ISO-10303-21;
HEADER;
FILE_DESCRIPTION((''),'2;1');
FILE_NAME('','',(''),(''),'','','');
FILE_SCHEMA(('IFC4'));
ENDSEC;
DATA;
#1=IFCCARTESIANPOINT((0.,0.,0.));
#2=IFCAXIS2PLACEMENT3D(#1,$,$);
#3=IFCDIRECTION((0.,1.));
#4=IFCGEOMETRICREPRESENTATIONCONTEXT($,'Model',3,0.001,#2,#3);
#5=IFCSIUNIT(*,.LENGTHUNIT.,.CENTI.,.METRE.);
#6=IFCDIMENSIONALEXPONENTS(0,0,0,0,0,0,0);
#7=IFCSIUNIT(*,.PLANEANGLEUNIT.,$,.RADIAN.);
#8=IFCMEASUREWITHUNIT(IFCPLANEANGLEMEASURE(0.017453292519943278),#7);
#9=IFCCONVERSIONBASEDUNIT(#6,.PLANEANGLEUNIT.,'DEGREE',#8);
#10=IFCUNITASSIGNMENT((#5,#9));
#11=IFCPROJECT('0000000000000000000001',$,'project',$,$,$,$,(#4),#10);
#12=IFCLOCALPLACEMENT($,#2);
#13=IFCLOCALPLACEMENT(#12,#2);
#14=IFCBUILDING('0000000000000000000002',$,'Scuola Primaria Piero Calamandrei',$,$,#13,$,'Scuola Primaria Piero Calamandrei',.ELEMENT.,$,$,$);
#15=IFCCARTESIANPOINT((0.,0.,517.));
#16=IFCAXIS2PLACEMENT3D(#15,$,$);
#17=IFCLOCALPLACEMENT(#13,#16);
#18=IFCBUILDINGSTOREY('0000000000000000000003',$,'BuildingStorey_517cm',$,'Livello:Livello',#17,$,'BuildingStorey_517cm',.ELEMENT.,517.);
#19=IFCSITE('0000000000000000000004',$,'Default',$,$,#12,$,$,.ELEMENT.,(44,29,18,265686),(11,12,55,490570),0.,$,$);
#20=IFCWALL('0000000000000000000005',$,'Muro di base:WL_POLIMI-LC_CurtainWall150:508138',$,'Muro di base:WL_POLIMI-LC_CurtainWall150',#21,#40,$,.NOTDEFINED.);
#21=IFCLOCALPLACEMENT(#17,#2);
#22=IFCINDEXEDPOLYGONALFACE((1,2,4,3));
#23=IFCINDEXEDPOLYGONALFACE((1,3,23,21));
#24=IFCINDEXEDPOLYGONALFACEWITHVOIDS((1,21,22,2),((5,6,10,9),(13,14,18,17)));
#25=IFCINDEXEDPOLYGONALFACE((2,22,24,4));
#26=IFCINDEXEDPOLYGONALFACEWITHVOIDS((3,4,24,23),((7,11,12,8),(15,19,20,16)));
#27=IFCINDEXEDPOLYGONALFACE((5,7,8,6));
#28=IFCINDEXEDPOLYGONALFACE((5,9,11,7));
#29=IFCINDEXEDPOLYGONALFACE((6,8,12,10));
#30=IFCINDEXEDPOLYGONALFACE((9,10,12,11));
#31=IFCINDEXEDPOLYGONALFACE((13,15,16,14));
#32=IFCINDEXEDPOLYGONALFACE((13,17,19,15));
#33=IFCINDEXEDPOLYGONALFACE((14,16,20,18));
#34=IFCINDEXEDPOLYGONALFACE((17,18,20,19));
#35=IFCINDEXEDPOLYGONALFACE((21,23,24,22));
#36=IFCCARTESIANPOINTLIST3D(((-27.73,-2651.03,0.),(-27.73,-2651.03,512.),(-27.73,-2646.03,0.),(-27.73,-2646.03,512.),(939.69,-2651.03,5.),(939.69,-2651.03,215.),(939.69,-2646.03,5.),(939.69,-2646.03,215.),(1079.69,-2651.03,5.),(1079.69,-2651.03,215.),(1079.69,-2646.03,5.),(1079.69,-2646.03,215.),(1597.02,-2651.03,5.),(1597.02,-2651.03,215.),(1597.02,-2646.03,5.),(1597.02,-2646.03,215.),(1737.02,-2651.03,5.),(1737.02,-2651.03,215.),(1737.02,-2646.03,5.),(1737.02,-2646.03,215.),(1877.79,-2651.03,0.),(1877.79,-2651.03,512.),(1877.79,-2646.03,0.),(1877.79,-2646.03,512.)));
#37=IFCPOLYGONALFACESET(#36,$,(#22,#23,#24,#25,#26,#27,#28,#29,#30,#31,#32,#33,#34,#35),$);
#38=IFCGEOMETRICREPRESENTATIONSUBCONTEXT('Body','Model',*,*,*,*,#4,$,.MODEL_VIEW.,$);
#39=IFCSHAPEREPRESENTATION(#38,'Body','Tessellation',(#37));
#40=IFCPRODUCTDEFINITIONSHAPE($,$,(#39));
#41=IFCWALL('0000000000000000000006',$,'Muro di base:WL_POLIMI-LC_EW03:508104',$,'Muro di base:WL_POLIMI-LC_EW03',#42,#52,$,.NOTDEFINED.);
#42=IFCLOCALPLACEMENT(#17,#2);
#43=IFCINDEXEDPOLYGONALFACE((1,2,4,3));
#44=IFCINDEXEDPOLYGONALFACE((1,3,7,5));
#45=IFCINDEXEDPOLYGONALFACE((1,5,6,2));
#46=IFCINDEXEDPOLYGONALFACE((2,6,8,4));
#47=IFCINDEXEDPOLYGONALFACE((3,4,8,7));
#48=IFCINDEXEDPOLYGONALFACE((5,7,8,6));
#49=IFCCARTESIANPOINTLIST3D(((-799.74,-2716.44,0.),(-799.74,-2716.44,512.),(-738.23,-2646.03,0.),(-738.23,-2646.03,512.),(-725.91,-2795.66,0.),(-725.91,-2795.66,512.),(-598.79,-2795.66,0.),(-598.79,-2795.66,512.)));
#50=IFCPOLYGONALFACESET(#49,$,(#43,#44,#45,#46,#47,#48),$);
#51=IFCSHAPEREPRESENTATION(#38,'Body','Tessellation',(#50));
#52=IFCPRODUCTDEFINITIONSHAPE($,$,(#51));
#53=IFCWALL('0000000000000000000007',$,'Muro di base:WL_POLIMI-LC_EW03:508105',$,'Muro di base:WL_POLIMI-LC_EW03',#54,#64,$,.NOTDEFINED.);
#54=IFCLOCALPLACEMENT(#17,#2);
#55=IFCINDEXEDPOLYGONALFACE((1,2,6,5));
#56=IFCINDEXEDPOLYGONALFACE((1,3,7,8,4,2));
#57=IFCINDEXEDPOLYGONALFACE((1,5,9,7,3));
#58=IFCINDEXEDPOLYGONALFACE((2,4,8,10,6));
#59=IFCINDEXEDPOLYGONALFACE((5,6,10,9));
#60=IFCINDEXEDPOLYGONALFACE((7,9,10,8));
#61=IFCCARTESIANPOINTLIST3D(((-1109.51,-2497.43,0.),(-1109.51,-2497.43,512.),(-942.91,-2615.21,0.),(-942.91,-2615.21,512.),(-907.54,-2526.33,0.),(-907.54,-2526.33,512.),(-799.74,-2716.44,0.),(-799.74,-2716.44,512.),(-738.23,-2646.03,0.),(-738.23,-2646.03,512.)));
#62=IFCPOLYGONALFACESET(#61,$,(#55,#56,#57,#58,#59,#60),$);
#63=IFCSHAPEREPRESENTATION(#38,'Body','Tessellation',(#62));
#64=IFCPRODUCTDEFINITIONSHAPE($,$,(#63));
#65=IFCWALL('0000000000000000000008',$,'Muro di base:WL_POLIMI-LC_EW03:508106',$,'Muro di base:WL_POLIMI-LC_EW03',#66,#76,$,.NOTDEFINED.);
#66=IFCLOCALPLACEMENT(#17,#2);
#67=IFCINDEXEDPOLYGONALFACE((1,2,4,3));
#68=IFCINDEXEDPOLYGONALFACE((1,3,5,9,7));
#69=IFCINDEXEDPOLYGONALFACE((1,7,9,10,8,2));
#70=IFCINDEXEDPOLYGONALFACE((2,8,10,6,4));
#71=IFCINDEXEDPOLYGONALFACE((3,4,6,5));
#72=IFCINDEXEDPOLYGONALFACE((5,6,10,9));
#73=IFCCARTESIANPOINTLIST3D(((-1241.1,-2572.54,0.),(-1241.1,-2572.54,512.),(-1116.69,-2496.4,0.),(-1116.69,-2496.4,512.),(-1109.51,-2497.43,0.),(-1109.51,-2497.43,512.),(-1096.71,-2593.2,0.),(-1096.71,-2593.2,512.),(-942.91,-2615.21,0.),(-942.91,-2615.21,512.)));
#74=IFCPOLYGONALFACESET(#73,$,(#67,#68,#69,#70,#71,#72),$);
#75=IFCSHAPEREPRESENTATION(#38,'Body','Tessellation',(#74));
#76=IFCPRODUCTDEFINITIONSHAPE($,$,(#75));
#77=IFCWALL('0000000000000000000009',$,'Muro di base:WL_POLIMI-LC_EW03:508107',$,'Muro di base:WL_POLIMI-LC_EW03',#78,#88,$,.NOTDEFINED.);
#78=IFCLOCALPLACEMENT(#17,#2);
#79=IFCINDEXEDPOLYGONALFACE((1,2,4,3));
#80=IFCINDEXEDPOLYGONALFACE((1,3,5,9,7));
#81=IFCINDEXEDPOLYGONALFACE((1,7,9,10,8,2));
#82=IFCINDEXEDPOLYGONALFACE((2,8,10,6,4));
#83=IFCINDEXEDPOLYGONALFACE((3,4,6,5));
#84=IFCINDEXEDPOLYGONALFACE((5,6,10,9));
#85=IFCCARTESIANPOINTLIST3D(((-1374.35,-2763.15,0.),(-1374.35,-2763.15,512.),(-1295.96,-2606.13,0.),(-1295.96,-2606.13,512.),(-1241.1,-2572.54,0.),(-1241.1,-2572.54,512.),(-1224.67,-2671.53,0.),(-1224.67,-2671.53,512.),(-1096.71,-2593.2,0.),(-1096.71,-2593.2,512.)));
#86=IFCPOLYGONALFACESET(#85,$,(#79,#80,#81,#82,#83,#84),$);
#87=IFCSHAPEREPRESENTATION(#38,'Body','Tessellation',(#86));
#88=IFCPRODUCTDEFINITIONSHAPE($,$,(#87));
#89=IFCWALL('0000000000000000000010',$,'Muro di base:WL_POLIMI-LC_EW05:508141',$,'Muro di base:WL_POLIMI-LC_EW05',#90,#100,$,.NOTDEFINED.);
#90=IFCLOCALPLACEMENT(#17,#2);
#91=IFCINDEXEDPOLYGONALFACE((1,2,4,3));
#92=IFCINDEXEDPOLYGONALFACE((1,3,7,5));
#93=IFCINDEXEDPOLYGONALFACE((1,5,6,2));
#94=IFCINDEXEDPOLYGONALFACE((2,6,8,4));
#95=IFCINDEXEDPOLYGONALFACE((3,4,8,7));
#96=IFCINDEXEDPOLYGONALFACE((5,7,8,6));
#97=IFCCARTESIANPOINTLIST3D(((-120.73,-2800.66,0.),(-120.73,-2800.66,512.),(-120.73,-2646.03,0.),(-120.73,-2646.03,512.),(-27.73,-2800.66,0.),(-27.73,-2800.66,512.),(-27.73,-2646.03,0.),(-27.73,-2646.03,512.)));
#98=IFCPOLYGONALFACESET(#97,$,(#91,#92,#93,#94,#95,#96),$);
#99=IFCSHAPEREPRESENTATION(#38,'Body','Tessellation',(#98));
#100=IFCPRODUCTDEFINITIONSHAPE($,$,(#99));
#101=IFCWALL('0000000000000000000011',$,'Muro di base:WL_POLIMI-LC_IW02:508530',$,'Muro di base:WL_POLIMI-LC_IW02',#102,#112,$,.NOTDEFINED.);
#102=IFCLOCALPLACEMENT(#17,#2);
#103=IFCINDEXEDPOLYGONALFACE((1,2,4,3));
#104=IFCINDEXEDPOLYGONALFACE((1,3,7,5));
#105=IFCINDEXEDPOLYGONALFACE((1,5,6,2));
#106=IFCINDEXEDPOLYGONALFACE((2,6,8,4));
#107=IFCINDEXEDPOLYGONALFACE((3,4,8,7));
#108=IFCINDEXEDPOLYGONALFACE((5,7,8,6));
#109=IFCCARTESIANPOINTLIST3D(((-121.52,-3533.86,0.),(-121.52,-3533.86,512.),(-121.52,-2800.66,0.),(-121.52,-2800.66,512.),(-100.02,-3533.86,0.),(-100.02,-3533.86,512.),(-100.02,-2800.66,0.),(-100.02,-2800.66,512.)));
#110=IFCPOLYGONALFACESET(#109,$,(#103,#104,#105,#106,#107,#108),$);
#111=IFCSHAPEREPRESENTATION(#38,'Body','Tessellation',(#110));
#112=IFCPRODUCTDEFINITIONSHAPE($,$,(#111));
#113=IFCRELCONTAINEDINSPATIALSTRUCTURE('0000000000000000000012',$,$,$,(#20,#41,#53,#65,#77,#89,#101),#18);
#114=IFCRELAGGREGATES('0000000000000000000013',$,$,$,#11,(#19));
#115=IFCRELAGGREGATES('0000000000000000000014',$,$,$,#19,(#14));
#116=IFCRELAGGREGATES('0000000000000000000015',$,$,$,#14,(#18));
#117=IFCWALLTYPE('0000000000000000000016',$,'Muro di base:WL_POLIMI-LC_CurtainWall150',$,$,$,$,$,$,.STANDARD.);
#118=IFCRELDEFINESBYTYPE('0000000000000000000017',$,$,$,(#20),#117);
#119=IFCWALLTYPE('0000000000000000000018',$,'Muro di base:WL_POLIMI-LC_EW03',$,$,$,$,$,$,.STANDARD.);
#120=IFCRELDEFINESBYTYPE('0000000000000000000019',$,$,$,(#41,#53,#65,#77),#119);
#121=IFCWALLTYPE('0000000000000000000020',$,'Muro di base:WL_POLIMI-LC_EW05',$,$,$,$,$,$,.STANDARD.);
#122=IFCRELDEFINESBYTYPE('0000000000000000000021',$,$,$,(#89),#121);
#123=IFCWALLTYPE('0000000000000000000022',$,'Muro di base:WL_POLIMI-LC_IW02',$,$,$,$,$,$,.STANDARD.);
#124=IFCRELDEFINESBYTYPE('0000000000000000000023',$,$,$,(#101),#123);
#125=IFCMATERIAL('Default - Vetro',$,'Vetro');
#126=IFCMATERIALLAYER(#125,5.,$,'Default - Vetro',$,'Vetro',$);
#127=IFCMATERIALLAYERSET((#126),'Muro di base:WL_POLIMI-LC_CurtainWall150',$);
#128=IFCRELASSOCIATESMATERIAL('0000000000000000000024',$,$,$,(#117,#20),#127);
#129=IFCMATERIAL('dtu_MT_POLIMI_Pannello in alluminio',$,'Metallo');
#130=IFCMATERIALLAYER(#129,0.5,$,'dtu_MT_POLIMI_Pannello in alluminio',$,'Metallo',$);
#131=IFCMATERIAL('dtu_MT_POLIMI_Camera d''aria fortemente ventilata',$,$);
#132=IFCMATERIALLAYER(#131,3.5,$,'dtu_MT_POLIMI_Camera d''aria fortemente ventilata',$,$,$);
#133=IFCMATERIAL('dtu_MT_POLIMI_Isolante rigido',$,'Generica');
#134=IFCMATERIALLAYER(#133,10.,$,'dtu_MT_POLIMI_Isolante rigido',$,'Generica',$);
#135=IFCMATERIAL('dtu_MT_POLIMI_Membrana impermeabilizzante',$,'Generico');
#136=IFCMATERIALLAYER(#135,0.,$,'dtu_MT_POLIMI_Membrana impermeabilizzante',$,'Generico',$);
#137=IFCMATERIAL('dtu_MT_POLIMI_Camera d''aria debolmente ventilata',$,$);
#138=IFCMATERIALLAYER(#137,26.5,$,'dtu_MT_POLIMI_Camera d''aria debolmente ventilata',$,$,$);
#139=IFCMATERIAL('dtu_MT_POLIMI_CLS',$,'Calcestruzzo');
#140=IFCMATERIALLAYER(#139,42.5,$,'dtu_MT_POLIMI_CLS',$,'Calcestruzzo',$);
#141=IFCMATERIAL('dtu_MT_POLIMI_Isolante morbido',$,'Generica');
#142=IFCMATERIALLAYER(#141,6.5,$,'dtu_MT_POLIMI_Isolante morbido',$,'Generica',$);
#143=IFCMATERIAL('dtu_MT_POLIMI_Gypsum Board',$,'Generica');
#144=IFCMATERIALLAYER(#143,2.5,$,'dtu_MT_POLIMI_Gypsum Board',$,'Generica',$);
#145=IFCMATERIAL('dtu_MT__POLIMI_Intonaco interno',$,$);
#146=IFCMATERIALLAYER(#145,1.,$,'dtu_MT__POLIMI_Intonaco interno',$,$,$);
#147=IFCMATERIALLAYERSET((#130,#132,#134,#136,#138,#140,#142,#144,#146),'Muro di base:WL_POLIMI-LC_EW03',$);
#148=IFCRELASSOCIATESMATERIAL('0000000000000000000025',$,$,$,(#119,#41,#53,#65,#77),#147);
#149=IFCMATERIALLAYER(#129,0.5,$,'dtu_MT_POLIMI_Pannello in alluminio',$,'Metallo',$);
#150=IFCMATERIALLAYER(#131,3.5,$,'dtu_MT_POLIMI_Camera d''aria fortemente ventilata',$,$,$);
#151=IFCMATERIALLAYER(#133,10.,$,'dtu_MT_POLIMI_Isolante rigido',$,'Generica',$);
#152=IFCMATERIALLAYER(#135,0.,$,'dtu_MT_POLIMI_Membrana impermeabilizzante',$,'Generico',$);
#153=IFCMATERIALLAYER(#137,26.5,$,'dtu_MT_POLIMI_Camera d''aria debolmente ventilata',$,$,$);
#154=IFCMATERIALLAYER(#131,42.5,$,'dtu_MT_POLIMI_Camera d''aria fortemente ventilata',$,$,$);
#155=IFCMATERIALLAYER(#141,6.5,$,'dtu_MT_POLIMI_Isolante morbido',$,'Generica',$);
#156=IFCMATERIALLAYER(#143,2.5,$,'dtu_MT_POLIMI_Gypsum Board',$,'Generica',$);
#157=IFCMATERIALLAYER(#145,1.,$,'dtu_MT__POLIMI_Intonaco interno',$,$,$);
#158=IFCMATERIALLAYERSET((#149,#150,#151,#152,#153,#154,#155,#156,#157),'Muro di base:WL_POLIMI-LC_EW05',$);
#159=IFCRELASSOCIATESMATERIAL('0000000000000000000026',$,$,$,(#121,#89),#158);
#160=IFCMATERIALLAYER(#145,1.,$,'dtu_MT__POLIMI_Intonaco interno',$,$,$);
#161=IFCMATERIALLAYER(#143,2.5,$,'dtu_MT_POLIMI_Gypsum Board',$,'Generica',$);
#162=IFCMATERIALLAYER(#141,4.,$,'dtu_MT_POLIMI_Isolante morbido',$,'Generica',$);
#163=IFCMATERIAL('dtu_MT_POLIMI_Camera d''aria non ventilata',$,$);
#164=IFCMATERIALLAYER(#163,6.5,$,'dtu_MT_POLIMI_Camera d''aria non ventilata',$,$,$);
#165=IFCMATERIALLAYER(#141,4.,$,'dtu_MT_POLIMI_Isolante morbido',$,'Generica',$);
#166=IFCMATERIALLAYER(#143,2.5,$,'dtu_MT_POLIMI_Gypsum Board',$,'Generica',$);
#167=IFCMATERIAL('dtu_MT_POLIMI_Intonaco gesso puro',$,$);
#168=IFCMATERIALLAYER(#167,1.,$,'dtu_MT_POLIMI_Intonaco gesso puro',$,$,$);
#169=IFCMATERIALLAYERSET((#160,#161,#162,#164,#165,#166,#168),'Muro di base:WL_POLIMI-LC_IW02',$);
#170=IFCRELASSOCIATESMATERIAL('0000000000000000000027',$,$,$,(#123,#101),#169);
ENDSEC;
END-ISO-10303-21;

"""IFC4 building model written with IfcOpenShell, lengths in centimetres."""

from ifc_helpers import new_model, entity, si_unit, converted_unit, direction, frame, frame_2d, origin, place, context, subcontext, project, spatial, polyline, rectangle, outline, extrude, material, layer, layer_set, layer_usage, type_object, element, save


model = new_model("IFC4")

# Units and contexts
model_context = context("Model", 3, precision=0.001, world=origin(), true_north=direction((0.0, 1.0)))
body_context = subcontext(model_context, "Body", "Model", "MODEL_VIEW")
ifc_project = project(units=[si_unit("LENGTHUNIT", "METRE", prefix="CENTI"), converted_unit("PLANEANGLEUNIT", "DEGREE", entity("IfcPlaneAngleMeasure", 0.017453292519943278), si_unit("PLANEANGLEUNIT", "RADIAN"), dimensions=[0, 0, 0, 0, 0, 0, 0])], contexts=[model_context])

# Site, building, storey
site_placement = place(None, origin())
site = spatial("IfcSite", under=ifc_project, at=site_placement, Name="Default", CompositionType="ELEMENT", RefLatitude=(44, 29, 18, 265686), RefLongitude=(11, 12, 55, 490570), RefElevation=0.0)
building_placement = place(site_placement, origin())
building = spatial("IfcBuilding", under=site, at=building_placement, Name="Scuola Primaria Piero Calamandrei", LongName="Scuola Primaria Piero Calamandrei", CompositionType="ELEMENT")
storey_placement = place(building_placement, frame((0.0, 0.0, 517.0)))
storey = spatial("IfcBuildingStorey", under=building, at=storey_placement, Name="BuildingStorey_517cm", ObjectType="Livello:Livello", LongName="BuildingStorey_517cm", CompositionType="ELEMENT", Elevation=517.0)

# Shared definitions
ifc_material_1 = material(Name="dtu_MT_POLIMI_Isolante rigido", Category="Generica")
ifc_material_2 = material(Name="dtu_MT__POLIMI_Intonaco interno")

# Shared definitions
ifc_material_3 = material(Name="Default - Vetro", Category="Vetro")
ifc_layer_1 = layer(ifc_material_3, 5.0, Name="Default - Vetro", Category="Vetro")
ifc_layer_set_1 = layer_set([ifc_layer_1], Name="Muro di base:WL_POLIMI-LC_CurtainWall150")
wall_type_1 = type_object("IfcWallType", Name="Muro di base:WL_POLIMI-LC_CurtainWall150", PredefinedType="STANDARD", material=ifc_layer_set_1)

# Wall, openings
ifc_layer_usage_1 = layer_usage(ifc_layer_set_1, "AXIS2", "NEGATIVE", 2.5)
wall_1_placement = place(storey_placement, frame((-27.73, -2648.53, 0.0)))
wall_1 = element("IfcWall", 1, at=wall_1_placement, inside=storey, type_object=wall_type_1, material=ifc_layer_usage_1, Name="Muro di base:WL_POLIMI-LC_CurtainWall150:508138", ObjectType="Muro di base:WL_POLIMI-LC_CurtainWall150", PredefinedType="NOTDEFINED", context=body_context, shape_type="SweptSolid", body=[
    extrude(rectangle(XDim=1905.52, YDim=5.0, at=frame_2d((952.76, 0.0), x_axis=(-1.0, 0.0))), origin(), (0.0, 0.0, 1.0), 512.0),
])
opening_1_placement = place(wall_1_placement, frame((1624.75, -2.5, 5.0)))
element("IfcOpeningElement", 2, at=opening_1_placement, cuts=wall_1, PredefinedType="OPENING", context=body_context, shape_type="SweptSolid", body=[
    extrude(rectangle(XDim=210.0, YDim=140.0, at=frame_2d((105.0, 70.0), x_axis=(-1.0, 0.0))), frame((0.0, 0.0, 0.0), z_axis=(0.0, 1.0, 0.0), x_axis=(0.0, 0.0, 1.0)), (0.0, 0.0, 1.0), 5.0),
])
opening_2_placement = place(wall_1_placement, frame((967.42, -2.5, 5.0)))
element("IfcOpeningElement", 3, at=opening_2_placement, cuts=wall_1, PredefinedType="OPENING", context=body_context, shape_type="SweptSolid", body=[
    extrude(rectangle(XDim=210.0, YDim=140.0, at=frame_2d((105.0, 70.0), x_axis=(-1.0, 0.0))), frame((0.0, 0.0, 0.0), z_axis=(0.0, 1.0, 0.0), x_axis=(0.0, 0.0, 1.0)), (0.0, 0.0, 1.0), 5.0),
])

# Walls
ifc_material_4 = material(Name="dtu_MT_POLIMI_Pannello in alluminio", Category="Metallo")
ifc_layer_2 = layer(ifc_material_4, 0.5, Name="dtu_MT_POLIMI_Pannello in alluminio", Category="Metallo")
ifc_material_5 = material(Name="dtu_MT_POLIMI_Camera d'aria fortemente ventilata")
ifc_layer_3 = layer(ifc_material_5, 3.5, Name="dtu_MT_POLIMI_Camera d'aria fortemente ventilata")
ifc_layer_4 = layer(ifc_material_1, 10.0, Name="dtu_MT_POLIMI_Isolante rigido", Category="Generica")
ifc_material_6 = material(Name="dtu_MT_POLIMI_Membrana impermeabilizzante", Category="Generico")
ifc_layer_5 = layer(ifc_material_6, 0.0, Name="dtu_MT_POLIMI_Membrana impermeabilizzante", Category="Generico")
ifc_material_7 = material(Name="dtu_MT_POLIMI_Camera d'aria debolmente ventilata")
ifc_layer_6 = layer(ifc_material_7, 26.5, Name="dtu_MT_POLIMI_Camera d'aria debolmente ventilata")
ifc_material_8 = material(Name="dtu_MT_POLIMI_CLS", Category="Calcestruzzo")
ifc_layer_7 = layer(ifc_material_8, 42.5, Name="dtu_MT_POLIMI_CLS", Category="Calcestruzzo")
ifc_material_9 = material(Name="dtu_MT_POLIMI_Isolante morbido", Category="Generica")
ifc_layer_8 = layer(ifc_material_9, 6.5, Name="dtu_MT_POLIMI_Isolante morbido", Category="Generica")
ifc_material_10 = material(Name="dtu_MT_POLIMI_Gypsum Board", Category="Generica")
ifc_layer_9 = layer(ifc_material_10, 2.5, Name="dtu_MT_POLIMI_Gypsum Board", Category="Generica")
ifc_layer_10 = layer(ifc_material_2, 1.0, Name="dtu_MT__POLIMI_Intonaco interno")
ifc_layer_set_2 = layer_set([ifc_layer_2, ifc_layer_3, ifc_layer_4, ifc_layer_5, ifc_layer_6, ifc_layer_7, ifc_layer_8, ifc_layer_9, ifc_layer_10], Name="Muro di base:WL_POLIMI-LC_EW03")
ifc_layer_usage_2 = layer_usage(ifc_layer_set_2, "AXIS2", "NEGATIVE", 46.5)
wall_type_2 = type_object("IfcWallType", Name="Muro di base:WL_POLIMI-LC_EW03", PredefinedType="STANDARD", material=ifc_layer_set_2)
wall_2_placement = place(storey_placement, frame((-772.25, -2677.73, 0.0), z_axis=(0.0, 0.0, 1.0), x_axis=(0.681735, -0.731599, 0.0)))
element("IfcWall", 4, at=wall_2_placement, inside=storey, type_object=wall_type_2, material=ifc_layer_usage_2, Name="Muro di base:WL_POLIMI-LC_EW03:508104", ObjectType="Muro di base:WL_POLIMI-LC_EW03", PredefinedType="NOTDEFINED", context=body_context, shape_type="SweptSolid", body=[
    extrude(outline(polyline([(117.87, -46.5), (204.53, 46.5), (0.0, 46.5), (9.58, -46.5), (117.87, -46.5)])), origin(), (0.0, 0.0, 1.0), 512.0),
])
ifc_layer_usage_3 = layer_usage(ifc_layer_set_2, "AXIS2", "NEGATIVE", 46.5)
wall_3_placement = place(storey_placement, frame((-1082.67, -2459.46, 0.0), z_axis=(0.0, 0.0, 1.0), x_axis=(0.816533, -0.577299, 0.0)))
element("IfcWall", 5, at=wall_3_placement, inside=storey, type_object=wall_type_2, material=ifc_layer_usage_3, Name="Muro di base:WL_POLIMI-LC_EW03:508105", ObjectType="Muro di base:WL_POLIMI-LC_EW03", PredefinedType="NOTDEFINED", context=body_context, shape_type="SweptSolid", body=[
    extrude(outline(polyline([(379.38, -46.5), (388.96, 46.5), (181.6, 46.5), (0.0, -46.5), (204.03, -46.5), (379.38, -46.5)])), origin(), (0.0, 0.0, 1.0), 512.0),
])
ifc_layer_usage_4 = layer_usage(ifc_layer_set_2, "AXIS2", "NEGATIVE", 46.5)
wall_4_placement = place(storey_placement, frame((-1234.51, -2526.51, 0.0), z_axis=(0.0, 0.0, 1.0), x_axis=(0.989918, -0.141644, 0.0)))
element("IfcWall", 6, at=wall_4_placement, inside=storey, type_object=wall_type_2, material=ifc_layer_usage_4, Name="Muro di base:WL_POLIMI-LC_EW03:508106", ObjectType="Muro di base:WL_POLIMI-LC_EW03", PredefinedType="NOTDEFINED", context=body_context, shape_type="SweptSolid", body=[
    extrude(outline(polyline([(301.22, -46.5), (119.62, 46.5), (112.36, 46.5), (0.0, -46.5), (145.86, -46.5), (301.22, -46.5)])), origin(), (0.0, 0.0, 1.0), 512.0),
])
ifc_layer_usage_5 = layer_usage(ifc_layer_set_2, "AXIS2", "NEGATIVE", 46.5)
wall_5_placement = place(storey_placement, frame((-1398.62, -2723.48, 0.0), z_axis=(0.0, 0.0, 1.0), x_axis=(0.85291, 0.522058, 0.0)))
element("IfcWall", 7, at=wall_5_placement, inside=storey, type_object=wall_type_2, material=ifc_layer_usage_5, Name="Muro di base:WL_POLIMI-LC_EW03:508107", ObjectType="Muro di base:WL_POLIMI-LC_EW03", PredefinedType="NOTDEFINED", context=body_context, shape_type="SweptSolid", body=[
    extrude(outline(polyline([(325.52, -46.5), (213.16, 46.5), (148.82, 46.5), (0.0, -46.5), (175.49, -46.5), (325.52, -46.5)])), origin(), (0.0, 0.0, 1.0), 512.0),
])
ifc_layer_11 = layer(ifc_material_4, 0.5, Name="dtu_MT_POLIMI_Pannello in alluminio", Category="Metallo")
ifc_layer_12 = layer(ifc_material_5, 3.5, Name="dtu_MT_POLIMI_Camera d'aria fortemente ventilata")
ifc_layer_13 = layer(ifc_material_1, 10.0, Name="dtu_MT_POLIMI_Isolante rigido", Category="Generica")
ifc_layer_14 = layer(ifc_material_6, 0.0, Name="dtu_MT_POLIMI_Membrana impermeabilizzante", Category="Generico")
ifc_layer_15 = layer(ifc_material_7, 26.5, Name="dtu_MT_POLIMI_Camera d'aria debolmente ventilata")
ifc_layer_16 = layer(ifc_material_5, 42.5, Name="dtu_MT_POLIMI_Camera d'aria fortemente ventilata")
ifc_layer_17 = layer(ifc_material_9, 6.5, Name="dtu_MT_POLIMI_Isolante morbido", Category="Generica")
ifc_layer_18 = layer(ifc_material_10, 2.5, Name="dtu_MT_POLIMI_Gypsum Board", Category="Generica")
ifc_layer_19 = layer(ifc_material_2, 1.0, Name="dtu_MT__POLIMI_Intonaco interno")
ifc_layer_set_3 = layer_set([ifc_layer_11, ifc_layer_12, ifc_layer_13, ifc_layer_14, ifc_layer_15, ifc_layer_16, ifc_layer_17, ifc_layer_18, ifc_layer_19], Name="Muro di base:WL_POLIMI-LC_EW05")
ifc_layer_usage_6 = layer_usage(ifc_layer_set_3, "AXIS2", "NEGATIVE", 46.5)
wall_type_3 = type_object("IfcWallType", Name="Muro di base:WL_POLIMI-LC_EW05", PredefinedType="STANDARD", material=ifc_layer_set_3)
wall_6_placement = place(storey_placement, frame((-74.23, -2800.66, 0.0), z_axis=(0.0, 0.0, 1.0), x_axis=(0.0, 1.0, 0.0)))
element("IfcWall", 8, at=wall_6_placement, inside=storey, type_object=wall_type_3, material=ifc_layer_usage_6, Name="Muro di base:WL_POLIMI-LC_EW05:508141", ObjectType="Muro di base:WL_POLIMI-LC_EW05", PredefinedType="NOTDEFINED", context=body_context, shape_type="SweptSolid", body=[
    extrude(rectangle(XDim=154.63, YDim=93.0, at=frame_2d((77.32, 0.0), x_axis=(-1.0, 0.0))), origin(), (0.0, 0.0, 1.0), 512.0),
])
ifc_layer_20 = layer(ifc_material_2, 1.0, Name="dtu_MT__POLIMI_Intonaco interno")
ifc_layer_21 = layer(ifc_material_10, 2.5, Name="dtu_MT_POLIMI_Gypsum Board", Category="Generica")
ifc_layer_22 = layer(ifc_material_9, 4.0, Name="dtu_MT_POLIMI_Isolante morbido", Category="Generica")
ifc_material_11 = material(Name="dtu_MT_POLIMI_Camera d'aria non ventilata")
ifc_layer_23 = layer(ifc_material_11, 6.5, Name="dtu_MT_POLIMI_Camera d'aria non ventilata")
ifc_layer_24 = layer(ifc_material_9, 4.0, Name="dtu_MT_POLIMI_Isolante morbido", Category="Generica")
ifc_layer_25 = layer(ifc_material_10, 2.5, Name="dtu_MT_POLIMI_Gypsum Board", Category="Generica")
ifc_material_12 = material(Name="dtu_MT_POLIMI_Intonaco gesso puro")
ifc_layer_26 = layer(ifc_material_12, 1.0, Name="dtu_MT_POLIMI_Intonaco gesso puro")
ifc_layer_set_4 = layer_set([ifc_layer_20, ifc_layer_21, ifc_layer_22, ifc_layer_23, ifc_layer_24, ifc_layer_25, ifc_layer_26], Name="Muro di base:WL_POLIMI-LC_IW02")
ifc_layer_usage_7 = layer_usage(ifc_layer_set_4, "AXIS2", "NEGATIVE", 10.75)
wall_type_4 = type_object("IfcWallType", Name="Muro di base:WL_POLIMI-LC_IW02", PredefinedType="STANDARD", material=ifc_layer_set_4)
wall_7_placement = place(storey_placement, frame((-110.77, -2800.66, 0.0), z_axis=(0.0, 0.0, 1.0), x_axis=(0.0, -1.0, 0.0)))
element("IfcWall", 9, at=wall_7_placement, inside=storey, type_object=wall_type_4, material=ifc_layer_usage_7, Name="Muro di base:WL_POLIMI-LC_IW02:508530", ObjectType="Muro di base:WL_POLIMI-LC_IW02", PredefinedType="NOTDEFINED", context=body_context, shape_type="SweptSolid", body=[
    extrude(rectangle(XDim=733.19, YDim=21.5, at=frame_2d((366.6, 0.0), x_axis=(-1.0, 0.0))), origin(), (0.0, 0.0, 1.0), 512.0),
])

save(model, "model.ifc")
